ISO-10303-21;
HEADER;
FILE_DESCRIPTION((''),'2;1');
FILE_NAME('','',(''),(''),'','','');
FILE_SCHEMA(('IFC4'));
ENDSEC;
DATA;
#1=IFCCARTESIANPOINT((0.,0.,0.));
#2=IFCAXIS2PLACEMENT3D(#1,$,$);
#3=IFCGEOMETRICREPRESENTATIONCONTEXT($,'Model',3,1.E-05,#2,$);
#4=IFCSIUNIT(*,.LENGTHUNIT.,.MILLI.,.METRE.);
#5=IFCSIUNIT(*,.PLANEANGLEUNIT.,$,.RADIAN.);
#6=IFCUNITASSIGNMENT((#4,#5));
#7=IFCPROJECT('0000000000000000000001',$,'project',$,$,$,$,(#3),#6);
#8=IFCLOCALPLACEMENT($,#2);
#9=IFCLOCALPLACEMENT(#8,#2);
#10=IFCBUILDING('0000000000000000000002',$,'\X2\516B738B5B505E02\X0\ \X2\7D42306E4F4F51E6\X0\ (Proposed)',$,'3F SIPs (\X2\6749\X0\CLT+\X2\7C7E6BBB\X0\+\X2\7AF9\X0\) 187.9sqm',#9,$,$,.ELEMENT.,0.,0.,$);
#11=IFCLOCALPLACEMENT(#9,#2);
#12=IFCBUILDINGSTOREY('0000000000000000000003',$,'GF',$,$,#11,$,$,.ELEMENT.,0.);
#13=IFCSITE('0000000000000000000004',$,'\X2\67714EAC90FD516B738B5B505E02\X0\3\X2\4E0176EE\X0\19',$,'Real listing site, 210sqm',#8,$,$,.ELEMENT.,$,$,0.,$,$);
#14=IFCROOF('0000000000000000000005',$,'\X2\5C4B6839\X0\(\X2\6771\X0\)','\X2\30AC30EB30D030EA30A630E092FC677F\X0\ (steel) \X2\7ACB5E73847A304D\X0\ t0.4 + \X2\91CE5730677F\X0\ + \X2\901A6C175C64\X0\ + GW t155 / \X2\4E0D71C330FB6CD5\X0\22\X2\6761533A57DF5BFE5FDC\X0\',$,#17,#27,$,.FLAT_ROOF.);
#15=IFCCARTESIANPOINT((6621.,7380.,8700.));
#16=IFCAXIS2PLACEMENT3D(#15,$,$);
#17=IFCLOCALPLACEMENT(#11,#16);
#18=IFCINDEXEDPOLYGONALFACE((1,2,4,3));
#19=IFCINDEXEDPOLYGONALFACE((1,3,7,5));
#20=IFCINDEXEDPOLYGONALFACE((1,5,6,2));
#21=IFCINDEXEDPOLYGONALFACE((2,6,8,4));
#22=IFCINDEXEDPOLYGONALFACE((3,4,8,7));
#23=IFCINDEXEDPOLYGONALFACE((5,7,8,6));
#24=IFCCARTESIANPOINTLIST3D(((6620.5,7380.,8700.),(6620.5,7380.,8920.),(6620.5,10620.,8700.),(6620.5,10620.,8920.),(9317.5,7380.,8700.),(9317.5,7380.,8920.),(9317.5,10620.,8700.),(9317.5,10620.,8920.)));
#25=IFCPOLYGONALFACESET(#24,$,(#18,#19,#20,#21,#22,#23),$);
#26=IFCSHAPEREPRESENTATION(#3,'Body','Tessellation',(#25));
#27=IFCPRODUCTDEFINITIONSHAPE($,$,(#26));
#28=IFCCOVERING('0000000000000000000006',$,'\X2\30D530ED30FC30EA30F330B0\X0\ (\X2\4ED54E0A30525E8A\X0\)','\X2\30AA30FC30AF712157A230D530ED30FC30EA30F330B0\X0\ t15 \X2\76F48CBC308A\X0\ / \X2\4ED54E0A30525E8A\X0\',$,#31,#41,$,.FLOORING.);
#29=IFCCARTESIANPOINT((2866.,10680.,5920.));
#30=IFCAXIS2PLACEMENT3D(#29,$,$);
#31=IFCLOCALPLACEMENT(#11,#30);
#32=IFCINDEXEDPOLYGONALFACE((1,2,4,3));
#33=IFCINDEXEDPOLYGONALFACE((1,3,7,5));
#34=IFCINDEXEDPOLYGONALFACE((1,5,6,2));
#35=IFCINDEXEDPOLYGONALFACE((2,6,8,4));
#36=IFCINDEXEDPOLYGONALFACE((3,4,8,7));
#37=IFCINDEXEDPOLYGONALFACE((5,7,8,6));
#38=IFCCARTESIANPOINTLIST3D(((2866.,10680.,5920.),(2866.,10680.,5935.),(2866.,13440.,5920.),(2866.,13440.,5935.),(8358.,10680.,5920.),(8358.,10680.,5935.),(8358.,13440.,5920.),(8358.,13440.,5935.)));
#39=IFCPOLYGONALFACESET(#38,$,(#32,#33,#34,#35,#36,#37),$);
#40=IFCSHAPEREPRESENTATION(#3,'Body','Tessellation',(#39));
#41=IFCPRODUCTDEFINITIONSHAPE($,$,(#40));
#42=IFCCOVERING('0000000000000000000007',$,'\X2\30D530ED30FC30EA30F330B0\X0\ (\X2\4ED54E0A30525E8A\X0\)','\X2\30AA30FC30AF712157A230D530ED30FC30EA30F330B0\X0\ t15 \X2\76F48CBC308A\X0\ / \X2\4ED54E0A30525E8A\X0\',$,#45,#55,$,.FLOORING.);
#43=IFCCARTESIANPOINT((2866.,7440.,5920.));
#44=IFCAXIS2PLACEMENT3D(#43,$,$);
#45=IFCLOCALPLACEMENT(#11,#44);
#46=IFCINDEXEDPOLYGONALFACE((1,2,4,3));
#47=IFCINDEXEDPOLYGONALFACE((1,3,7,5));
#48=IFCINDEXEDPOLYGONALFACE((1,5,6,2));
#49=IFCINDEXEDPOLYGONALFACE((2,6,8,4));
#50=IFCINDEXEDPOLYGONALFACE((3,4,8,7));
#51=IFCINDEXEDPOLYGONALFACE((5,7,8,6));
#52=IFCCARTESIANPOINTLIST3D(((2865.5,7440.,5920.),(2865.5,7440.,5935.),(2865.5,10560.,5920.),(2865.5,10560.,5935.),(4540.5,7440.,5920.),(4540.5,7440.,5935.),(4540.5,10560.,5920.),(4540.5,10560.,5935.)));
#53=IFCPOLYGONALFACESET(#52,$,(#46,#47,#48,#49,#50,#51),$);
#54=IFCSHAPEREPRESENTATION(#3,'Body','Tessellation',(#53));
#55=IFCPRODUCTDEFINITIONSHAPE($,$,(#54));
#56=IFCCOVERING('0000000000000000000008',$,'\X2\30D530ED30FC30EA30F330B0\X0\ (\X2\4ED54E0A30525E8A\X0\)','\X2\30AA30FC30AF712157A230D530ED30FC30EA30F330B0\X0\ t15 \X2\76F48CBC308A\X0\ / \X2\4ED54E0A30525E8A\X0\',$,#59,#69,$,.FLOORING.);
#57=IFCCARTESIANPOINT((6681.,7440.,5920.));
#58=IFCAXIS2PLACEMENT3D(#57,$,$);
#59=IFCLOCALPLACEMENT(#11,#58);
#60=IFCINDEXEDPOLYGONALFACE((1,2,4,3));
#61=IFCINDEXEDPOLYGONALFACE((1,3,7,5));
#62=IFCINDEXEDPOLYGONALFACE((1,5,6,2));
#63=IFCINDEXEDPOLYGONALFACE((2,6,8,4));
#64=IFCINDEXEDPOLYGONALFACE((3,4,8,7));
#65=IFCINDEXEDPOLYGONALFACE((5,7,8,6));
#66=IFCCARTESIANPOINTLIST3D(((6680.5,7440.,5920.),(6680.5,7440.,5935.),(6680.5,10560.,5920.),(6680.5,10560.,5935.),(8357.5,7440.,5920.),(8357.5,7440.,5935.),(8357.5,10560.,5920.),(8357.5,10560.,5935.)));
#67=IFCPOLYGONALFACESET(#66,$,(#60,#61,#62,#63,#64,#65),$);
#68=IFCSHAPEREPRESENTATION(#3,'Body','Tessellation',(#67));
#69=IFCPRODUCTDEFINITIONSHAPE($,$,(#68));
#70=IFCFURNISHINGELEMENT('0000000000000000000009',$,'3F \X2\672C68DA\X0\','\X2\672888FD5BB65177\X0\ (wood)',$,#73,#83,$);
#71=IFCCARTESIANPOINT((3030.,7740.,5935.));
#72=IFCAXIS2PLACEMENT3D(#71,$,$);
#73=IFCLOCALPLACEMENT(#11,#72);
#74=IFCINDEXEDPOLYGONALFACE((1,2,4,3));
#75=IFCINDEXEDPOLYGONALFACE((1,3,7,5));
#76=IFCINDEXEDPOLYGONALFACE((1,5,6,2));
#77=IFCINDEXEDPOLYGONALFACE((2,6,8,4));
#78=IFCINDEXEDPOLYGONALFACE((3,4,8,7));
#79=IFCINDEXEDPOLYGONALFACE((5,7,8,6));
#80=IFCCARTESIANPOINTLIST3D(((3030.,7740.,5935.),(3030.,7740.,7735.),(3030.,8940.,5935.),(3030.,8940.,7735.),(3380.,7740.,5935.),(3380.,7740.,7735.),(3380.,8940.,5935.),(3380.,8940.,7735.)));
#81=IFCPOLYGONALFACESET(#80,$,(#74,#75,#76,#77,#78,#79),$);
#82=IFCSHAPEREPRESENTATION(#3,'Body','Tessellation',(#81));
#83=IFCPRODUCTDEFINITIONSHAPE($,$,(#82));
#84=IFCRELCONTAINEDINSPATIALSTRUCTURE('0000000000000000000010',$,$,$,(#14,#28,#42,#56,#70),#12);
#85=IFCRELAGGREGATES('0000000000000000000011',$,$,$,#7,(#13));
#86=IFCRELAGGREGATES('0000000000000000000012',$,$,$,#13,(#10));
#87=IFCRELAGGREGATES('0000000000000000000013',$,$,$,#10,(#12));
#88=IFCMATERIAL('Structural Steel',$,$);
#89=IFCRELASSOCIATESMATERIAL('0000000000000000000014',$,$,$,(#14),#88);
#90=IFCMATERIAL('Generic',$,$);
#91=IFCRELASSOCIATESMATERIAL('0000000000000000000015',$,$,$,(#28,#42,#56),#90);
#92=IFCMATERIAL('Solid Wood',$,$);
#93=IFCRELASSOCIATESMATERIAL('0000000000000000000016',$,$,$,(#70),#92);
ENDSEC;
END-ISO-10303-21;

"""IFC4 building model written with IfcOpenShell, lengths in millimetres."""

from ifc_helpers import new_model, si_unit, frame, frame_2d, origin, place, context, project, spatial, rectangle, extrude, material, element, save


model = new_model("IFC4")

# Units and contexts
model_context = context("Model", 3, precision=1e-05, world=origin())
ifc_project = project(units=[si_unit("LENGTHUNIT", "METRE", prefix="MILLI"), si_unit("PLANEANGLEUNIT", "RADIAN")], contexts=[model_context])

# Site, building, storey
site_placement = place(None, origin())
site = spatial("IfcSite", under=ifc_project, at=site_placement, Name="東京都八王子市3丁目19", ObjectType="Real listing site, 210sqm", CompositionType="ELEMENT", RefElevation=0.0)
building_placement = place(site_placement, origin())
building = spatial("IfcBuilding", under=site, at=building_placement, Name="八王子市 終の住処 (Proposed)", ObjectType="3F SIPs (杉CLT+籾殻+竹) 187.9sqm", CompositionType="ELEMENT", ElevationOfRefHeight=0.0, ElevationOfTerrain=0.0)
storey_placement = place(building_placement, origin())
storey = spatial("IfcBuildingStorey", under=building, at=storey_placement, Name="GF", CompositionType="ELEMENT", Elevation=0.0)

# Shared definitions
ifc_material_1 = material(Name="Solid Wood")

# Shared definitions
ifc_material_2 = material(Name="Generic")

# Roof
ifc_material_3 = material(Name="Structural Steel")
roof_1_placement = place(storey_placement, frame((6621.0, 7380.0, 8700.0)))
element("IfcRoof", 1, at=roof_1_placement, inside=storey, material=ifc_material_3, Name="屋根(東)", Description="ガルバリウム鋼板 (steel) 立平葺き t0.4 + 野地板 + 通気層 + GW t155 / 不燃・法22条区域対応", PredefinedType="FLAT_ROOF", context=model_context, shape_type="SweptSolid", body=[
    extrude(rectangle(XDim=2697.0, YDim=3240.0, at=frame_2d((1348.0, 1620.0))), frame((6621.0, 7380.0, 8700.0)), (0.0, 0.0, 1.0), 220.0),
])

# Coverings
covering_1_placement = place(storey_placement, frame((2866.0, 10680.0, 5920.0)))
element("IfcCovering", 2, at=covering_1_placement, inside=storey, material=ifc_material_2, Name="フローリング (仕上げ床)", Description="オーク無垢フローリング t15 直貼り / 仕上げ床", PredefinedType="FLOORING", context=model_context, shape_type="SweptSolid", body=[
    extrude(rectangle(XDim=5492.0, YDim=2760.0, at=frame_2d((2746.0, 1380.0))), frame((2866.0, 10680.0, 5920.0)), (0.0, 0.0, 1.0), 15.0),
])
covering_2_placement = place(storey_placement, frame((2866.0, 7440.0, 5920.0)))
element("IfcCovering", 3, at=covering_2_placement, inside=storey, material=ifc_material_2, Name="フローリング (仕上げ床)", Description="オーク無垢フローリング t15 直貼り / 仕上げ床", PredefinedType="FLOORING", context=model_context, shape_type="SweptSolid", body=[
    extrude(rectangle(XDim=1675.0, YDim=3120.0, at=frame_2d((837.0, 1560.0))), frame((2866.0, 7440.0, 5920.0)), (0.0, 0.0, 1.0), 15.0),
])
covering_3_placement = place(storey_placement, frame((6681.0, 7440.0, 5920.0)))
element("IfcCovering", 4, at=covering_3_placement, inside=storey, material=ifc_material_2, Name="フローリング (仕上げ床)", Description="オーク無垢フローリング t15 直貼り / 仕上げ床", PredefinedType="FLOORING", context=model_context, shape_type="SweptSolid", body=[
    extrude(rectangle(XDim=1677.0, YDim=3120.0, at=frame_2d((838.0, 1560.0))), frame((6681.0, 7440.0, 5920.0)), (0.0, 0.0, 1.0), 15.0),
])

# Furnishing element
furnishing_placement = place(storey_placement, frame((3030.0, 7740.0, 5935.0)))
element("IfcFurnishingElement", 5, at=furnishing_placement, inside=storey, material=ifc_material_1, Name="3F 本棚", Description="木製家具 (wood)", context=model_context, shape_type="SweptSolid", body=[
    extrude(rectangle(XDim=350.0, YDim=1200.0, at=frame_2d((175.0, 600.0))), frame((3030.0, 7740.0, 5935.0)), (0.0, 0.0, 1.0), 1800.0),
])

save(model, "model.ifc")
